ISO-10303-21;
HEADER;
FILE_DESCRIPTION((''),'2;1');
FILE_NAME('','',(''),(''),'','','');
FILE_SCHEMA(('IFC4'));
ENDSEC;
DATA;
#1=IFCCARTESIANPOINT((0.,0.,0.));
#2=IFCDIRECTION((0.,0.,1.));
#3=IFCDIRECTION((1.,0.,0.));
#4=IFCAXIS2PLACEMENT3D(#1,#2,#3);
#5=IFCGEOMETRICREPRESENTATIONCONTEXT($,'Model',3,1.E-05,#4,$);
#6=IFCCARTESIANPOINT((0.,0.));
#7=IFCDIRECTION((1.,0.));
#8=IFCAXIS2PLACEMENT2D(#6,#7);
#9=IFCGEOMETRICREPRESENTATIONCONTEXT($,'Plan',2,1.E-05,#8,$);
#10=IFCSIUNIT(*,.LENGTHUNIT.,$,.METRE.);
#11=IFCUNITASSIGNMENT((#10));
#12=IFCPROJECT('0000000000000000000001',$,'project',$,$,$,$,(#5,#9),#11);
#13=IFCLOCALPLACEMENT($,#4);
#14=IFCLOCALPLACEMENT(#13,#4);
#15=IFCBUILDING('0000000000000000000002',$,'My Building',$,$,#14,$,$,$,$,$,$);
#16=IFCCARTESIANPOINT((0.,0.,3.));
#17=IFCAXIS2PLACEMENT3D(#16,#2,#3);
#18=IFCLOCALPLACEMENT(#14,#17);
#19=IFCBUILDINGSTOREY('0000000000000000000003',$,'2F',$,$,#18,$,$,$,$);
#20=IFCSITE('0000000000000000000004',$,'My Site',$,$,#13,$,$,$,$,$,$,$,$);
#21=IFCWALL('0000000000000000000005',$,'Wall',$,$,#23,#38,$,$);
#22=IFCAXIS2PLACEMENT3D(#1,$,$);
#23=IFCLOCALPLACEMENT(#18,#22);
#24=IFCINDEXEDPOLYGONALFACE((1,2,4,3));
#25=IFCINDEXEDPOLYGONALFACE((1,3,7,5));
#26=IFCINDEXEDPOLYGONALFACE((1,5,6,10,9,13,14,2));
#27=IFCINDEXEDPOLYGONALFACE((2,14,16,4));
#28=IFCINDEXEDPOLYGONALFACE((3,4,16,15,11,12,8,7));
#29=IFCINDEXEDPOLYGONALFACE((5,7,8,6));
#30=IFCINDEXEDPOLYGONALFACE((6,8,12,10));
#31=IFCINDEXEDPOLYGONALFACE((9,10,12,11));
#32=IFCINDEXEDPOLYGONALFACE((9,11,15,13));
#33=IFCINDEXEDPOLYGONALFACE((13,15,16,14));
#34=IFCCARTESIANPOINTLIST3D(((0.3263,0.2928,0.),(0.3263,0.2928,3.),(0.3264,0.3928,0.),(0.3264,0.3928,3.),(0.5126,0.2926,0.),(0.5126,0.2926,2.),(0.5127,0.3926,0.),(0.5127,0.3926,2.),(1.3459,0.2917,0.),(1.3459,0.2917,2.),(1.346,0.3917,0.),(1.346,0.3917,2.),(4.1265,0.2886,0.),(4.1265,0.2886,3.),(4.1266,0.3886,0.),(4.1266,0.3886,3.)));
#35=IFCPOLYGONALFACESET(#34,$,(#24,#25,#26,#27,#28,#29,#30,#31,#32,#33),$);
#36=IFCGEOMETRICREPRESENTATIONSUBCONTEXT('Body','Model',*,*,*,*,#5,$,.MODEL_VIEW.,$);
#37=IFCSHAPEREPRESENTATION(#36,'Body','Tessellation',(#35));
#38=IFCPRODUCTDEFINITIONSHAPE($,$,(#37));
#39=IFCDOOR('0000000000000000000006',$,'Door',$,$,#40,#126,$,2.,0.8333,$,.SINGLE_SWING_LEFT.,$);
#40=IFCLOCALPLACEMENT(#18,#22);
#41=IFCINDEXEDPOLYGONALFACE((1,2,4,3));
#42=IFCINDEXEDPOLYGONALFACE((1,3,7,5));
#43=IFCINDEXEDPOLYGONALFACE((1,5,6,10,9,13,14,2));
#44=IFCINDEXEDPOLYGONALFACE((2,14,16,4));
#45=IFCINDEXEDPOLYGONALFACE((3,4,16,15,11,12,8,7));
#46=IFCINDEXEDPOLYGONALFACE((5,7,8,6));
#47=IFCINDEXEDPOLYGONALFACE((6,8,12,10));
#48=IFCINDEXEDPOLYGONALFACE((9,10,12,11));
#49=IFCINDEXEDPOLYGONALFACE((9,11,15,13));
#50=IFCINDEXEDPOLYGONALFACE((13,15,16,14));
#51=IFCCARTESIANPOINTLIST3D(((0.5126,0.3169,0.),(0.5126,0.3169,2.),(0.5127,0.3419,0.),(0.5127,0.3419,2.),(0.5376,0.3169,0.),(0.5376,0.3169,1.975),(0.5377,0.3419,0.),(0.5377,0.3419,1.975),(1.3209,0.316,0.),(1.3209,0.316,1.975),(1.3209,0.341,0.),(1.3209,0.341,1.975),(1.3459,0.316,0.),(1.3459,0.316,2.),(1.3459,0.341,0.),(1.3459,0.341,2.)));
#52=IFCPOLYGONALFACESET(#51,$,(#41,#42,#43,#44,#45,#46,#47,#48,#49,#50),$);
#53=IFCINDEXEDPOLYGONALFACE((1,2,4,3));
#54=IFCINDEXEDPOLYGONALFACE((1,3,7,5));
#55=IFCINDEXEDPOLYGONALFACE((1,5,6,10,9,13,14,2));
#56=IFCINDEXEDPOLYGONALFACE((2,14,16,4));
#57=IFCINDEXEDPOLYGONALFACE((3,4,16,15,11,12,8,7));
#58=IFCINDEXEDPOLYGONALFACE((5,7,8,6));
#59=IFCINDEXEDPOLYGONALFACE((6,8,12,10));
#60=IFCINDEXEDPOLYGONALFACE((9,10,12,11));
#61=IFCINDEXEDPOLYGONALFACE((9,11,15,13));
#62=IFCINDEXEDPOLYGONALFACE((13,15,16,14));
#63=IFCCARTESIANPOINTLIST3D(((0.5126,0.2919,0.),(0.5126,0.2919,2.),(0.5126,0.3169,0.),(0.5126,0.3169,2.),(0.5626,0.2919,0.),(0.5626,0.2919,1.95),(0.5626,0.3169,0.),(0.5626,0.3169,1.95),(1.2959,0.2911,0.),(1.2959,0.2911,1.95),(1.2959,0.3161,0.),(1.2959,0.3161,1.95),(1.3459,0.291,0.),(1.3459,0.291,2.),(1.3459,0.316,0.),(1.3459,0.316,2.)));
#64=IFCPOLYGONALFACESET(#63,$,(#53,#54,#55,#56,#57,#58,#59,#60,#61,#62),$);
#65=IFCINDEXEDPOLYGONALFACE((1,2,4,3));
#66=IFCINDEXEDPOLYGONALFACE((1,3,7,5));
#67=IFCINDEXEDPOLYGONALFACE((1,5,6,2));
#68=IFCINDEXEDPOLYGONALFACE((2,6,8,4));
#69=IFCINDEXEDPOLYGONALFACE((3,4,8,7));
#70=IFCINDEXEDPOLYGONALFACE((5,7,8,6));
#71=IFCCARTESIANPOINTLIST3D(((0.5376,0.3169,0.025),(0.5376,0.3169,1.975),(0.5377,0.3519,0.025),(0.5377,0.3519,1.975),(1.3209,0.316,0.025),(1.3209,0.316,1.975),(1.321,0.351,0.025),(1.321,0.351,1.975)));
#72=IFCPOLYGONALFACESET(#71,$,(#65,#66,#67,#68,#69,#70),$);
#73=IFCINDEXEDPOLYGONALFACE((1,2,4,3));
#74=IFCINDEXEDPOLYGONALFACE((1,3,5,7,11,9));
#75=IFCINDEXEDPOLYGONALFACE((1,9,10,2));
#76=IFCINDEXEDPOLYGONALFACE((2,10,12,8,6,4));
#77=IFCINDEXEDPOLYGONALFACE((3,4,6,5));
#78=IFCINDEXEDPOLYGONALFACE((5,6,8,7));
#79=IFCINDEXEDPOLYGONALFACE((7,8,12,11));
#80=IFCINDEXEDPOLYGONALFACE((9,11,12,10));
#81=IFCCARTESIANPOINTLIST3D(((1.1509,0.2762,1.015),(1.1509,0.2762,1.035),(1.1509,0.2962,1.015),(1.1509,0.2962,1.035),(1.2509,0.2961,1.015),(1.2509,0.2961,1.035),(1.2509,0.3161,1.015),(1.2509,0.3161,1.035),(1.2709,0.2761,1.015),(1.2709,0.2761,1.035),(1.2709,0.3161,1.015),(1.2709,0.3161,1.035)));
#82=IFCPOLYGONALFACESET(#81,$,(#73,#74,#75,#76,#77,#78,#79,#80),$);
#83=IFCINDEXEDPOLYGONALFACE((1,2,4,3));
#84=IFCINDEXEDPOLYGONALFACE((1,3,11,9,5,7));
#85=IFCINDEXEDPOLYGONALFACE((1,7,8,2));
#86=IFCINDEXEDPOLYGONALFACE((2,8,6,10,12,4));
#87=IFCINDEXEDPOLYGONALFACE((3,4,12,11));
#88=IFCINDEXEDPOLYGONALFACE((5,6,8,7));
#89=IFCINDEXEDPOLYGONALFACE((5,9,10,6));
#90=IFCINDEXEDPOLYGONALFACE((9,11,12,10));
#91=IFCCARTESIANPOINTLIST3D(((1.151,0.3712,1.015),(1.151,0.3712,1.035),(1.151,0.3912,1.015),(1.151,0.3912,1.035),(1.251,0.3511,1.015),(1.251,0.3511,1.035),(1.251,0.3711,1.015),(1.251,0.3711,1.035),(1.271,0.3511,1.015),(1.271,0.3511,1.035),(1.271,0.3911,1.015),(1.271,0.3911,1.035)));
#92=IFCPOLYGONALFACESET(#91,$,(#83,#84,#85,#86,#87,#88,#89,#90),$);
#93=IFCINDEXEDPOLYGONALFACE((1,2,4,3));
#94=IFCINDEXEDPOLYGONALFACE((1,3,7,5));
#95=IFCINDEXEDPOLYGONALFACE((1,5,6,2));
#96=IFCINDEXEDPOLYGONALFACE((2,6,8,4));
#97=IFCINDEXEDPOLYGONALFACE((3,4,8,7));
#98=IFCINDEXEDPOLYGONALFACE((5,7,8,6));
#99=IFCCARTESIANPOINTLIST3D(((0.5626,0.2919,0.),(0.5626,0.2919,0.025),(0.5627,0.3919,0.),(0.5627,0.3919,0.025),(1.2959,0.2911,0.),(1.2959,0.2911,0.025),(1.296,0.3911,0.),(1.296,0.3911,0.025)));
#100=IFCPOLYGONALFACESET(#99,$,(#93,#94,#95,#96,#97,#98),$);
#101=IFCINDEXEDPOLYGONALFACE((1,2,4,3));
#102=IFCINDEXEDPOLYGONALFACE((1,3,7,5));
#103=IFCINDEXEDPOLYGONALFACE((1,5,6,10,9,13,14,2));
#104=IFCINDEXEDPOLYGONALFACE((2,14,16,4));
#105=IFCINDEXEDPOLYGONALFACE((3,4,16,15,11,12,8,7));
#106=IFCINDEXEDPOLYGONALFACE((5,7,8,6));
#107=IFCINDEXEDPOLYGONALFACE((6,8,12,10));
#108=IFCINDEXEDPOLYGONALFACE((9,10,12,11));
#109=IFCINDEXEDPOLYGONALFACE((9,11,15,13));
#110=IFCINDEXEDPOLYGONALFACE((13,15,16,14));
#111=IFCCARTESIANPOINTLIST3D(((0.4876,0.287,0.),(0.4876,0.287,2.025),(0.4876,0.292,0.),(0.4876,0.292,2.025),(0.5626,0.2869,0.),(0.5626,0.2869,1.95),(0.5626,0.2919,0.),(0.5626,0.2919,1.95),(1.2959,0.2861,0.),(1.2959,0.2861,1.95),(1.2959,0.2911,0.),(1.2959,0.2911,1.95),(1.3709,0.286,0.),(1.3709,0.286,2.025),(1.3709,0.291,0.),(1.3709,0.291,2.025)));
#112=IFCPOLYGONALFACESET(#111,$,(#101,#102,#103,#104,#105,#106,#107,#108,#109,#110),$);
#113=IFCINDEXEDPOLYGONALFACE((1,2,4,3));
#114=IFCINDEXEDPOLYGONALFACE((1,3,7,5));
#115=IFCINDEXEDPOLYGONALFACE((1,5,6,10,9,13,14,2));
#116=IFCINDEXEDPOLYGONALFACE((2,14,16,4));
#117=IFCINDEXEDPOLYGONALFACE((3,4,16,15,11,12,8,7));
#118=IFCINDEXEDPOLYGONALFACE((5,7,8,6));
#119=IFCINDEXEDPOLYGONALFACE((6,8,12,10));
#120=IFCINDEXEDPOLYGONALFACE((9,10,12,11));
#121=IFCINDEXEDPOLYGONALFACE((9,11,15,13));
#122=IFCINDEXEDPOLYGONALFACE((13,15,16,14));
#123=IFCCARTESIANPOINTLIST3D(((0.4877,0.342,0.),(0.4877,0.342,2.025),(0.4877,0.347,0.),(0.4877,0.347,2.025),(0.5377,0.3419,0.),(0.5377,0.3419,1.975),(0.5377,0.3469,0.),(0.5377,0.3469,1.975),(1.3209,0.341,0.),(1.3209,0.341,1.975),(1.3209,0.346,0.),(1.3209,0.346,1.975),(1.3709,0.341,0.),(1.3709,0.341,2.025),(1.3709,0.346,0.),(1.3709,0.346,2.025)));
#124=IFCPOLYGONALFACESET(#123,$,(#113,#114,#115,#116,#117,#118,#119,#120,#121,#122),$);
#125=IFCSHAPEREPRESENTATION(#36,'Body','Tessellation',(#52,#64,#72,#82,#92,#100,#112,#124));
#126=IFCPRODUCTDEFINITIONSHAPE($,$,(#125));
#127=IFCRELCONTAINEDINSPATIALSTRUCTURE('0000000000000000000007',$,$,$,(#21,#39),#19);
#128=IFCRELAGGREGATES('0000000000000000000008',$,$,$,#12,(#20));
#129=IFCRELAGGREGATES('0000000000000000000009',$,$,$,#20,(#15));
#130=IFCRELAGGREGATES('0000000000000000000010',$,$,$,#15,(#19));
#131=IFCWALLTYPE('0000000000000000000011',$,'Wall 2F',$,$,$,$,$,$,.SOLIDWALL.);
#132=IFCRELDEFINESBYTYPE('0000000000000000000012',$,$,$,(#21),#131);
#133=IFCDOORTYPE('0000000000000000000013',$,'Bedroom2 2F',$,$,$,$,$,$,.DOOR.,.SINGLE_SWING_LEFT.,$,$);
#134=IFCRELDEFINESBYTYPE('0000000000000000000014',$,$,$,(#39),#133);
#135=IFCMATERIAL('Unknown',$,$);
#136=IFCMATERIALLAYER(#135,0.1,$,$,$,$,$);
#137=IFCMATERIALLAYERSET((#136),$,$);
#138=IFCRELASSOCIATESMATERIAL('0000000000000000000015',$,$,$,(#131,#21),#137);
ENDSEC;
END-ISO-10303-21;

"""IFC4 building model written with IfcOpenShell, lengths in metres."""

from ifc_helpers import new_model, entity, si_unit, frame, origin_with_axes, origin_2d_with_axis, place, context, subcontext, project, spatial, line, indexed_curve, outline, extrude, shape, source, transform, mapped, material, layer, layer_set, layer_usage, type_object, type_shapes, element, fill, save


model = new_model("IFC4")

# Units and contexts
model_context = context("Model", 3, precision=1e-05, world=origin_with_axes())
plan_context = context("Plan", 2, precision=1e-05, world=origin_2d_with_axis())
body_context_1 = subcontext(model_context, "Body", "Model", "MODEL_VIEW")
body_context_2 = subcontext(plan_context, "Body", "Plan", "PLAN_VIEW")
ifc_project = project(units=[si_unit("LENGTHUNIT", "METRE")], contexts=[model_context, plan_context])

# Site, building, storey
site_placement = place(None, origin_with_axes())
site = spatial("IfcSite", under=ifc_project, at=site_placement, Name="My Site")
building_placement = place(site_placement, origin_with_axes())
building = spatial("IfcBuilding", under=site, at=building_placement, Name="My Building")
storey_placement = place(building_placement, frame((0.0, 0.0, 3.0), z_axis=(0.0, 0.0, 1.0), x_axis=(1.0, 0.0, 0.0)))
storey = spatial("IfcBuildingStorey", under=building, at=storey_placement, Name="2F")

# Shared definitions
ifc_material = material(Name="Unknown")

# Shared definitions
ifc_layer_1 = layer(ifc_material, 0.1)
ifc_layer_set_1 = layer_set([ifc_layer_1])
wall_type = type_object("IfcWallType", Name="Wall 2F", PredefinedType="SOLIDWALL", material=ifc_layer_set_1)

# Wall, opening, door
ifc_layer_usage_1 = layer_usage(ifc_layer_set_1, "AXIS2", "POSITIVE", 0.0)
wall_1_placement = place(storey_placement, frame((4.1266, 0.3886, 0.0), z_axis=(0.0, 0.0, 1.0), x_axis=(-0.999999, 0.001117, 0.0)))
wall_1 = element("IfcWall", 1, at=wall_1_placement, inside=storey, type_object=wall_type, material=ifc_layer_usage_1, Name="Wall", context=body_context_1, shape_type="SweptSolid", body=[
    extrude(outline(indexed_curve([(0.0, 0.0), (0.0, 0.1), (3.8002, 0.1), (3.8002, 0.0)], segments=[line(1, 2, 3, 4, 1)])), origin_with_axes(), (0.0, 0.0, 1.0), 3.0),
])
shared_shape_1 = source(origin_with_axes(), body_context_1, "Body", "SweptSolid", [
    extrude(outline(indexed_curve([(0.0, 0.0), (0.8333, 0.0), (0.8333, 2.0), (0.0, 2.0)], segments=[line(1, 2, 3, 4, 1)])), frame((0.0, -0.6, 0.0), z_axis=(0.0, -1.0, 0.0), x_axis=(1.0, 0.0, 0.0)), (0.0, 0.0, -1.0), 1.2),
])
opening_1_placement = place(wall_1_placement, frame((3.6139, 0.1007, 0.0), z_axis=(0.0, 0.0, 1.0), x_axis=(-1.0, 0.000001, 0.0)))
opening_1 = element("IfcOpeningElement", 2, at=opening_1_placement, cuts=wall_1, PredefinedType="OPENING", context=body_context_1, shape_type="MappedRepresentation", body=[
    mapped(shared_shape_1, transform((0.0, 0.0, 0.0), x_axis=(1.0, 0.0, 0.0), y_axis=(0.0, 1.0, 0.0), z_axis=(0.0, 0.0, 1.0), scale=1.0)),
])
door_type_1 = type_object("IfcDoorType", Name="Bedroom2 2F", OperationType="SINGLE_SWING_LEFT", PredefinedType="DOOR")
shared_shape_2 = source(origin_with_axes(), body_context_1, "Body", "SweptSolid", [
    extrude(outline(indexed_curve([(0.0, 0.0), (0.0, 2.0), (0.8333, 2.0), (0.8333, 0.0), (0.8083, 0.0), (0.8083, 1.975), (0.025, 1.975), (0.025, 0.0)], segments=[line(1, 2, 3, 4, 5, 6, 7, 8, 1)])), frame((0.0, 0.025, 0.0), z_axis=(0.0, -1.0, 0.0), x_axis=(1.0, 0.0, 0.0)), (0.0, 0.0, -1.0), 0.025),
    extrude(outline(indexed_curve([(0.0, 0.0), (0.0, 2.0), (0.8333, 2.0), (0.8333, 0.0), (0.7833, 0.0), (0.7833, 1.95), (0.05, 1.95), (0.05, 0.0)], segments=[line(1, 2, 3, 4, 5, 6, 7, 8, 1)])), frame((0.0, 0.0, 0.0), z_axis=(0.0, -1.0, 0.0), x_axis=(1.0, 0.0, 0.0)), (0.0, 0.0, -1.0), 0.025),
    extrude(outline(indexed_curve([(0.0, 0.0), (0.7833, 0.0), (0.7833, 0.035), (0.0, 0.035)], segments=[line(1, 2, 3, 4, 1)])), frame((0.025, 0.025, 0.025), z_axis=(0.0, 0.0, 1.0), x_axis=(1.0, 0.0, 0.0)), (0.0, 0.0, 1.0), 1.95),
    extrude(outline(indexed_curve([(0.0, 0.0), (0.0, -0.04), (-0.12, -0.04), (-0.12, -0.02), (-0.02, -0.02), (-0.02, 0.0)], segments=[line(1, 2, 3, 4, 5, 6, 1)])), frame((0.7583, 0.025, 1.015), z_axis=(0.0, 0.0, 1.0), x_axis=(1.0, 0.0, 0.0)), (0.0, 0.0, 1.0), 0.02),
    extrude(outline(indexed_curve([(0.0, 0.0), (0.0, 0.04), (-0.12, 0.04), (-0.12, 0.02), (-0.02, 0.02), (-0.02, 0.0)], segments=[line(1, 2, 3, 4, 5, 6, 1)])), frame((0.7583, 0.06, 1.015), z_axis=(0.0, 0.0, 1.0), x_axis=(1.0, 0.0, 0.0)), (0.0, 0.0, 1.0), 0.02),
    extrude(outline(indexed_curve([(0.0, 0.0), (0.7333, 0.0), (0.7333, 0.1), (0.0, 0.1)], segments=[line(1, 2, 3, 4, 1)])), frame((0.05, 0.0, 0.0), z_axis=(0.0, 0.0, 1.0), x_axis=(1.0, 0.0, 0.0)), (0.0, 0.0, 1.0), 0.025),
    extrude(outline(indexed_curve([(0.0, 0.0), (0.0, 2.025), (0.8833, 2.025), (0.8833, 0.0), (0.8083, 0.0), (0.8083, 1.95), (0.075, 1.95), (0.075, 0.0)], segments=[line(1, 2, 3, 4, 5, 6, 7, 8, 1)])), frame((-0.025, -0.005, 0.0), z_axis=(0.0, -1.0, 0.0), x_axis=(1.0, 0.0, 0.0)), (0.0, 0.0, -1.0), 0.005),
    extrude(outline(indexed_curve([(0.0, 0.0), (0.0, 2.025), (0.8833, 2.025), (0.8833, 0.0), (0.8333, 0.0), (0.8333, 1.975), (0.05, 1.975), (0.05, 0.0)], segments=[line(1, 2, 3, 4, 5, 6, 7, 8, 1)])), frame((-0.025, 0.05, 0.0), z_axis=(0.0, -1.0, 0.0), x_axis=(1.0, 0.0, 0.0)), (0.0, 0.0, -1.0), 0.005),
])
shared_shape_3 = source(origin_with_axes(), body_context_2, "Body", "Curve2D", [
    entity("IfcIndexedPolyCurve", entity("IfcCartesianPointList2D", [[0.0, 0.0], [0.0, 0.05], [0.025, 0.05], [0.025, 0.025], [0.05, 0.025], [0.05, 0.0]]), [entity("IfcLineIndex", [1, 2, 3, 4, 5, 6, 1])]),
    entity("IfcIndexedPolyCurve", entity("IfcCartesianPointList2D", [[0.8333, 0.0], [0.8333, 0.05], [0.8083, 0.05], [0.8083, 0.025], [0.7833, 0.025], [0.7833, 0.0]]), [entity("IfcLineIndex", [1, 2, 3, 4, 5, 6, 1])]),
    entity("IfcTrimmedCurve", entity("IfcEllipse", entity("IfcAxis2Placement2D", entity("IfcCartesianPoint", [0.06, 0.05]), entity("IfcDirection", [1.0, 0.0])), 0.7483, 0.7833), [entity("IfcCartesianPoint", [0.8083, 0.05])], [entity("IfcCartesianPoint", [0.06, 0.8333])], True, "CARTESIAN"),
    entity("IfcIndexedPolyCurve", entity("IfcCartesianPointList2D", [[0.025, 0.05], [0.06, 0.05], [0.06, 0.8333], [0.025, 0.8333]]), [entity("IfcLineIndex", [1, 2, 3, 4, 1])]),
])
type_shapes(door_type_1, [shared_shape_2, shared_shape_3])
door_1_placement = place(opening_1_placement, frame((0.0, 0.0, 0.0), z_axis=(0.0, 0.0, 1.0), x_axis=(1.0, 0.0, 0.0)))
door_1 = element("IfcDoor", 3, at=door_1_placement, inside=storey, type_object=door_type_1, Name="Door", OperationType="SINGLE_SWING_LEFT", OverallHeight=2.0, OverallWidth=0.8333, shapes=[
    shape(body_context_1, "Body", "MappedRepresentation", [mapped(shared_shape_2, transform((0.0, 0.0, 0.0), x_axis=(1.0, 0.0, 0.0), y_axis=(0.0, 1.0, 0.0), z_axis=(0.0, 0.0, 1.0), scale=1.0))]),
    shape(body_context_2, "Body", "MappedRepresentation", [mapped(shared_shape_3, transform((0.0, 0.0, 0.0), x_axis=(1.0, 0.0, 0.0), y_axis=(0.0, 1.0, 0.0), z_axis=(0.0, 0.0, 1.0), scale=1.0))]),
])
fill(opening_1, door_1)

save(model, "model.ifc")
